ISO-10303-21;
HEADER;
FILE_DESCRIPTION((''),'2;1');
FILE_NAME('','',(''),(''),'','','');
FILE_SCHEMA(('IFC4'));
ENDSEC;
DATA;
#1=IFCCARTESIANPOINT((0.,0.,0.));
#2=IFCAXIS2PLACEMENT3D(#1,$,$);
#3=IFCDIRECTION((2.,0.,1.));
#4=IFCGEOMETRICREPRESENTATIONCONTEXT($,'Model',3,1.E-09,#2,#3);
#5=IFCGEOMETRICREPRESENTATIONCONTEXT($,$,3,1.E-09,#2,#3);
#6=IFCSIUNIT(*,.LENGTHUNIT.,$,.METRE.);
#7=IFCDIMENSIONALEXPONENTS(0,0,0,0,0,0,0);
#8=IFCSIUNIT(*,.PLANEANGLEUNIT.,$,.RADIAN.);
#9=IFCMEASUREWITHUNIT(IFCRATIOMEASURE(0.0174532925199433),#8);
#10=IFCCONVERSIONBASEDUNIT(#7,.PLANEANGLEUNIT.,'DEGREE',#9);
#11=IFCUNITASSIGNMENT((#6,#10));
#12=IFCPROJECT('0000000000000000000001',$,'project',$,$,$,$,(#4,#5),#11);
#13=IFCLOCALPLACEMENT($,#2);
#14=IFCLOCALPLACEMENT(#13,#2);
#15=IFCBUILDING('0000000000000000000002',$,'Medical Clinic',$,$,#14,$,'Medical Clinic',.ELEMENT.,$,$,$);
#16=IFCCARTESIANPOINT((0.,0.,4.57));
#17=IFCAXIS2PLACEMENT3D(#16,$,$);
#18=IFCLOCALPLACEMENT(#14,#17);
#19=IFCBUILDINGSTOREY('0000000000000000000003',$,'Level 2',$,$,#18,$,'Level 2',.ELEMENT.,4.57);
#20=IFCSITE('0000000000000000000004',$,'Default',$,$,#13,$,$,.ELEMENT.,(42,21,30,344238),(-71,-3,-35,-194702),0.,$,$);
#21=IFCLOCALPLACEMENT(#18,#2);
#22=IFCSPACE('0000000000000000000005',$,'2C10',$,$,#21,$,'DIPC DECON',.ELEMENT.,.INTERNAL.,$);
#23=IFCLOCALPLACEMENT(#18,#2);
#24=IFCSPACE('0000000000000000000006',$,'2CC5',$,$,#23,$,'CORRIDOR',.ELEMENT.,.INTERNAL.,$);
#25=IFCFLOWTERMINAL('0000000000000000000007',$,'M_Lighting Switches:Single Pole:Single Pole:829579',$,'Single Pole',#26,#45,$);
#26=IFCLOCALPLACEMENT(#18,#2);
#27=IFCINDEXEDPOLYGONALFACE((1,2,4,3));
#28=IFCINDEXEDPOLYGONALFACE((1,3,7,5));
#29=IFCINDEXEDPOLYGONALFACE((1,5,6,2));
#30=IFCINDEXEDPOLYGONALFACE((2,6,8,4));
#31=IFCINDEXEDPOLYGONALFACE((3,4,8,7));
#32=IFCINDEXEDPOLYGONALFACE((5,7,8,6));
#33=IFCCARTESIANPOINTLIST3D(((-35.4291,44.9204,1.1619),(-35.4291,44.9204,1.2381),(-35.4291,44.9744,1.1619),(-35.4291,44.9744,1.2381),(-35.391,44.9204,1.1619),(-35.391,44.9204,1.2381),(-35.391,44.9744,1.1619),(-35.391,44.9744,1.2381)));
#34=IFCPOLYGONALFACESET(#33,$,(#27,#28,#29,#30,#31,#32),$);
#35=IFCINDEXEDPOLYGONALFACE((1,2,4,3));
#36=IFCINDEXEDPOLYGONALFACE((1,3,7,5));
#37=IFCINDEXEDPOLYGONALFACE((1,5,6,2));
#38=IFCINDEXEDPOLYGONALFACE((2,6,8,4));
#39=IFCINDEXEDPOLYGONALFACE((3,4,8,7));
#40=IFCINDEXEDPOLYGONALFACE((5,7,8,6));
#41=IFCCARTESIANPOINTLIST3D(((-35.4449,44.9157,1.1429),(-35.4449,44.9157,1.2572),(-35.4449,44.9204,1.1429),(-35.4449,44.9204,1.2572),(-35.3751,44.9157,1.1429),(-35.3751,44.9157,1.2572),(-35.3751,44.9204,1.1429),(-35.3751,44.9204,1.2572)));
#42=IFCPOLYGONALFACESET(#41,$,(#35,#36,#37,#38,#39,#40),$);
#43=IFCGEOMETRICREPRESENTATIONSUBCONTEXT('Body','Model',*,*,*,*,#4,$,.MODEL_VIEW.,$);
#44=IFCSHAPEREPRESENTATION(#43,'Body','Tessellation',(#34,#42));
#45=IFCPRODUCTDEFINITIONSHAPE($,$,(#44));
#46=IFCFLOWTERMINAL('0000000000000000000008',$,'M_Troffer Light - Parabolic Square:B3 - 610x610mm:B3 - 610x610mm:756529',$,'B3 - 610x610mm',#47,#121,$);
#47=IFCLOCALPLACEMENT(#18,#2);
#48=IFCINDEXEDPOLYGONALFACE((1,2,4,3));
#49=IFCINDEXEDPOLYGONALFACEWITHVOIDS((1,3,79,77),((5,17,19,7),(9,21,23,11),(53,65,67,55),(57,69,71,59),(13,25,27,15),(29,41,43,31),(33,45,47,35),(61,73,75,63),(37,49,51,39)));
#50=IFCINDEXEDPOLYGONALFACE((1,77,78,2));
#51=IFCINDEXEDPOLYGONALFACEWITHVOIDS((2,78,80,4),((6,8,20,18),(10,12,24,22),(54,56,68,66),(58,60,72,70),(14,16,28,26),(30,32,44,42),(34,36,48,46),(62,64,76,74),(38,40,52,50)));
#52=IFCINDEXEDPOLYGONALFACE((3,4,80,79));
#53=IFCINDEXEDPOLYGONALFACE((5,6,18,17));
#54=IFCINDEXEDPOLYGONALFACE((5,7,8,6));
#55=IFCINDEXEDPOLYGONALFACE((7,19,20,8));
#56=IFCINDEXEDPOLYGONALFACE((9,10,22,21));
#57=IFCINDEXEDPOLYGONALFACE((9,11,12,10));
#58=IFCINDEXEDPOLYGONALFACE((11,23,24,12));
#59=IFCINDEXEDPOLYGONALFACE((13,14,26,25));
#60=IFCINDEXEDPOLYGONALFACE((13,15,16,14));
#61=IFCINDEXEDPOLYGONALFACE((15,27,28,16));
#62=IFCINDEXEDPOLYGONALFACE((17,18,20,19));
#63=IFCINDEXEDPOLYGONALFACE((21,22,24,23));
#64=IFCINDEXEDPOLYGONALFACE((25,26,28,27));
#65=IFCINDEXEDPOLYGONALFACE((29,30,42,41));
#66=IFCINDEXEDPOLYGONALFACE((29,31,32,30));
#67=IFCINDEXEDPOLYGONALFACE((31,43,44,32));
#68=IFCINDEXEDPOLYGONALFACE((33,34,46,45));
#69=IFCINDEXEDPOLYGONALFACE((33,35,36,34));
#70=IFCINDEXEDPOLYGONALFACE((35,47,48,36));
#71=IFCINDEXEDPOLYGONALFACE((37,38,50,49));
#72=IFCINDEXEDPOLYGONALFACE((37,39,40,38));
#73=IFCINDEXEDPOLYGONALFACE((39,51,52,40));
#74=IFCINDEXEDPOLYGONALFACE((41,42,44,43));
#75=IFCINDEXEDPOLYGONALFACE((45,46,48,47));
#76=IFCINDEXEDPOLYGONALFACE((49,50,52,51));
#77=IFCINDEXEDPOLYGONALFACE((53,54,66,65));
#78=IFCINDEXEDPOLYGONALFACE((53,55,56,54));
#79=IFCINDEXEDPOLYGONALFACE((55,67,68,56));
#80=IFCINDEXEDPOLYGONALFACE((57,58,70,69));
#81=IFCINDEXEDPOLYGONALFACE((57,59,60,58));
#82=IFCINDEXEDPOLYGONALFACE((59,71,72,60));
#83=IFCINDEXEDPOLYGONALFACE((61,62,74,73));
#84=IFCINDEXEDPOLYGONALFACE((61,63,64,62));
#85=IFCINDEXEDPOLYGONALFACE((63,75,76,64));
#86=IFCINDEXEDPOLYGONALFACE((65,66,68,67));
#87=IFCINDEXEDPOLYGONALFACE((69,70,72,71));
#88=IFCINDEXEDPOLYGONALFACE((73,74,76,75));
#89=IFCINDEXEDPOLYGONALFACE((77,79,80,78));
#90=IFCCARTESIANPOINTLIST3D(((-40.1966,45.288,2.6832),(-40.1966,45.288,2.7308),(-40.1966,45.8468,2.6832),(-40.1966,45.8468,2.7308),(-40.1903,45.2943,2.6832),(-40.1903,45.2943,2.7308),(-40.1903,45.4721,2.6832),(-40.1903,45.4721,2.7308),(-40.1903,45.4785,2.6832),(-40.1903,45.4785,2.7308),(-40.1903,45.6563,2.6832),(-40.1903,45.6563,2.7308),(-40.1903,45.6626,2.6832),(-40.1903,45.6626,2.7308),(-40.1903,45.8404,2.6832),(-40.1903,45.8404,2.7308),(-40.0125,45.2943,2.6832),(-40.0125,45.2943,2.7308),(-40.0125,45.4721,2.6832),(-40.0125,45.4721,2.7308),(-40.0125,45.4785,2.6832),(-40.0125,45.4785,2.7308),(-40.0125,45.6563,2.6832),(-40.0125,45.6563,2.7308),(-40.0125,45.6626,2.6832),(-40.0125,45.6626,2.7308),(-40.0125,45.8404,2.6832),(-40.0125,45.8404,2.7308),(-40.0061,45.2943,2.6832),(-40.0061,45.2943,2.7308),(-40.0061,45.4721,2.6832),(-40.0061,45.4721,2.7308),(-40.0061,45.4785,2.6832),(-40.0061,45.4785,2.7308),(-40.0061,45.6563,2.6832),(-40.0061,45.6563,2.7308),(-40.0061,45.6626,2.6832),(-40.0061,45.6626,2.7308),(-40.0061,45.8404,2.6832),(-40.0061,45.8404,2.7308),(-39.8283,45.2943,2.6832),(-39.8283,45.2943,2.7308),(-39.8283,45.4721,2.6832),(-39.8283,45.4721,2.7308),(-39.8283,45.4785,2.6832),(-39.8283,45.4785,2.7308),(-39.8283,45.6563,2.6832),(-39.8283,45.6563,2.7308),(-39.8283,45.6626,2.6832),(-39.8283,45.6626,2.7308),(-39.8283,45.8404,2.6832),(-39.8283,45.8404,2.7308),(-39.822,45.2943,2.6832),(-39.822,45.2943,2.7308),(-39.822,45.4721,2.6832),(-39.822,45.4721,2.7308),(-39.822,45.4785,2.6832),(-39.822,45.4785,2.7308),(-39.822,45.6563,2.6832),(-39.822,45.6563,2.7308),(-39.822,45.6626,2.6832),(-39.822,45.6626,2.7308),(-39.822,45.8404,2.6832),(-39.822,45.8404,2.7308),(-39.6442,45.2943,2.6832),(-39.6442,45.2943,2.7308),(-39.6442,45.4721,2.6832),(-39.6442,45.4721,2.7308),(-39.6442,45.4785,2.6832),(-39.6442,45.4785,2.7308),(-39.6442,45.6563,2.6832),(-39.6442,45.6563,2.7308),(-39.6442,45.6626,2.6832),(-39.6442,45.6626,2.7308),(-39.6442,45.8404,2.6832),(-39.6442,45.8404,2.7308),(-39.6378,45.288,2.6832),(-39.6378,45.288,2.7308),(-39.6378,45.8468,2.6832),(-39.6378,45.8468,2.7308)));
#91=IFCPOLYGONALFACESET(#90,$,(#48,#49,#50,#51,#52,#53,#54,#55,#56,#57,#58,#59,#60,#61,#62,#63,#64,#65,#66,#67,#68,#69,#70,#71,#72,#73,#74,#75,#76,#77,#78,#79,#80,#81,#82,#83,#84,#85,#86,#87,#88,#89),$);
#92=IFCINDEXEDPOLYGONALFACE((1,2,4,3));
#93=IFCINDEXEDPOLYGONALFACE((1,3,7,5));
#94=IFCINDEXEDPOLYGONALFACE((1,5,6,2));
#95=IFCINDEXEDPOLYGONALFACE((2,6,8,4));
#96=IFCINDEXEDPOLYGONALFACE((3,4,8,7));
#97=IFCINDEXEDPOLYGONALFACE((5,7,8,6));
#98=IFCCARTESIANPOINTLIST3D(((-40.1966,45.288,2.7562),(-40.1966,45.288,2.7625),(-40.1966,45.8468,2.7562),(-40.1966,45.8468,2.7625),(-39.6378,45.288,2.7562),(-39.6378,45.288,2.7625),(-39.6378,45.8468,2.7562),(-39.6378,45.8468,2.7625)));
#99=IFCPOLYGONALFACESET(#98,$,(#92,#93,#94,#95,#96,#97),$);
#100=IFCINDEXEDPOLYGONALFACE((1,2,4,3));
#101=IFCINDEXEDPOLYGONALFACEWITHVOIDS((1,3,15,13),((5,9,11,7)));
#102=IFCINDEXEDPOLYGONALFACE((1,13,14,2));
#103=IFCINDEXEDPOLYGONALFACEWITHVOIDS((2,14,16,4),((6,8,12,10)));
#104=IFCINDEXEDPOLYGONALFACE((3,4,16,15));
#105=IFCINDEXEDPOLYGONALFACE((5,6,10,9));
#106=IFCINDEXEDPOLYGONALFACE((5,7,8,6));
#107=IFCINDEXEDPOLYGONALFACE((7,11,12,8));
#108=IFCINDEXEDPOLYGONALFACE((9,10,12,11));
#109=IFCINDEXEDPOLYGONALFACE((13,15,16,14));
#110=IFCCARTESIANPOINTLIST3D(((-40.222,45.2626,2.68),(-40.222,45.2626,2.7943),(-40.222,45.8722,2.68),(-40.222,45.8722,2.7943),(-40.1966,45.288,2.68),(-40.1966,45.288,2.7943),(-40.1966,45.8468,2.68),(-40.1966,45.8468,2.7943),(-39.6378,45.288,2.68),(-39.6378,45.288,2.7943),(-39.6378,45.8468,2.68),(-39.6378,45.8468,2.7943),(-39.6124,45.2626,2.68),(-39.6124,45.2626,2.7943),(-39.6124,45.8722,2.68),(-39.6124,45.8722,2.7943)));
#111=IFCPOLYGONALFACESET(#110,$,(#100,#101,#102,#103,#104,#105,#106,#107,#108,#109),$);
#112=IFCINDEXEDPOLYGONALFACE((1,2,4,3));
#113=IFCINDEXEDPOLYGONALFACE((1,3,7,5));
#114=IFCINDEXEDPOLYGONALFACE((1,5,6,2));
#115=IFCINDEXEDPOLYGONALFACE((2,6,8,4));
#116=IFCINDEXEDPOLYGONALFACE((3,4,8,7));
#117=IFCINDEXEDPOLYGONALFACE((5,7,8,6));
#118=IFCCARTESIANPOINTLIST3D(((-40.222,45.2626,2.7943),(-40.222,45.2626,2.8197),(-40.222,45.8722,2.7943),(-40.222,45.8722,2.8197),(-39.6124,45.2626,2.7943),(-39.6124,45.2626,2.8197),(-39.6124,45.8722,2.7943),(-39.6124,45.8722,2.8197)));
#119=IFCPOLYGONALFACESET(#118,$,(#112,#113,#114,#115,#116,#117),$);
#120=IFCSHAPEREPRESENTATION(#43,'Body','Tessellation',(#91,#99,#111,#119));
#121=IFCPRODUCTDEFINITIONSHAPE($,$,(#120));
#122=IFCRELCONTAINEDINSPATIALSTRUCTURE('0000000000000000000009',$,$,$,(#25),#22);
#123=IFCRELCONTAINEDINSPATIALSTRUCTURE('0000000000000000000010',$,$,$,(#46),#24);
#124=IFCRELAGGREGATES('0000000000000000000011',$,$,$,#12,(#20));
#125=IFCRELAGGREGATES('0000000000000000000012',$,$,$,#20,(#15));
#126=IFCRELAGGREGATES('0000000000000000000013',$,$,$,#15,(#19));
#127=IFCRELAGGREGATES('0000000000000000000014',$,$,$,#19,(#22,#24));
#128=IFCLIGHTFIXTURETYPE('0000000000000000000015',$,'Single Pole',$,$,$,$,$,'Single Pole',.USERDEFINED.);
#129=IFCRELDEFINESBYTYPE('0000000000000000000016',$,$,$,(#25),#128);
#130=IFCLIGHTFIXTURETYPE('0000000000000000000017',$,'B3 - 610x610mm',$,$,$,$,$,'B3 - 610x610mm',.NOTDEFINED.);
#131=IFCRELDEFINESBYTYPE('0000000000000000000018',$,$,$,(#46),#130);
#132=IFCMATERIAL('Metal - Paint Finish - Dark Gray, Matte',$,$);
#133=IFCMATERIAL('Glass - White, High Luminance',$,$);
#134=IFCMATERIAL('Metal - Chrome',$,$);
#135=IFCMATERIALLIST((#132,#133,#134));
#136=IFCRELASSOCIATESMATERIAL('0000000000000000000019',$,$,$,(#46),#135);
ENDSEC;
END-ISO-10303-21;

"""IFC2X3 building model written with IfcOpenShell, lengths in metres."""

from ifc_helpers import new_model, entity, si_unit, converted_unit, direction, frame, frame_2d, origin, origin_2d_with_axis, place, context, subcontext, project, spatial, polyline, rectangle, outline, extrude, source, transform, mapped, material, material_list, type_object, type_shapes, element, save


model = new_model("IFC2X3")

# Units and contexts
model_context = context("Model", 3, precision=1e-09, world=origin(), true_north=direction((2.0, 0.0, 1.0)))
context_of_model = context(None, 3, precision=1e-09, world=origin(), true_north=direction((2.0, 0.0, 1.0)))
body_context = subcontext(model_context, "Body", "Model", "MODEL_VIEW")
ifc_project = project(units=[si_unit("LENGTHUNIT", "METRE"), converted_unit("PLANEANGLEUNIT", "DEGREE", entity("IfcRatioMeasure", 0.0174532925199433), si_unit("PLANEANGLEUNIT", "RADIAN"), dimensions=[0, 0, 0, 0, 0, 0, 0])], contexts=[model_context, context_of_model])

# Site, building, storey
site_placement = place(None, origin())
site = spatial("IfcSite", under=ifc_project, at=site_placement, Name="Default", CompositionType="ELEMENT", RefLatitude=(42, 21, 30, 344238), RefLongitude=(-71, -3, -35, -194702), RefElevation=0.0)
building_placement = place(site_placement, origin())
building = spatial("IfcBuilding", under=site, at=building_placement, Name="Medical Clinic", LongName="Medical Clinic", CompositionType="ELEMENT")
storey_placement = place(building_placement, frame((0.0, 0.0, 4.57)))
storey = spatial("IfcBuildingStorey", under=building, at=storey_placement, Name="Level 2", LongName="Level 2", CompositionType="ELEMENT", Elevation=4.57)

# Shared definitions
space_1_placement = place(storey_placement, origin())
space_1 = spatial("IfcSpace", under=storey, at=space_1_placement, Name="2C10", LongName="DIPC DECON", CompositionType="ELEMENT", InteriorOrExteriorSpace="INTERNAL")

# Shared definitions
light_fixture_type_1 = type_object("IfcLightFixtureType", Name="Single Pole", ElementType="Single Pole", PredefinedType="USERDEFINED")
shared_shape_1 = source(origin(), body_context, "Body", "SweptSolid", [
    extrude(rectangle(XDim=0.0381, YDim=0.0762, at=origin_2d_with_axis()), frame((0.0, 0.0, -0.054), z_axis=(0.0, 0.0, 1.0), x_axis=(-1.0, 0.0, 0.0)), (0.0, 0.0, 1.0), 0.054),
    extrude(rectangle(XDim=0.0698, YDim=0.1143, at=frame_2d((0.0, 0.0), x_axis=(1.0, 0.0))), frame((0.0, 0.0, 0.0), z_axis=(0.0, 0.0, 1.0), x_axis=(-1.0, 0.0, 0.0)), (0.0, 0.0, 1.0), 0.0048),
])
type_shapes(light_fixture_type_1, [shared_shape_1])

# Shared definitions
space_2_placement = place(storey_placement, origin())
space_2 = spatial("IfcSpace", under=storey, at=space_2_placement, Name="2CC5", LongName="CORRIDOR", CompositionType="ELEMENT", InteriorOrExteriorSpace="INTERNAL")

# Flow terminals
flow_terminal_1_placement = place(space_1_placement, frame((-35.41, 44.9204, 1.2), z_axis=(0.0, -1.0, 0.0), x_axis=(1.0, 0.0, 0.0)))
element("IfcFlowTerminal", 1, at=flow_terminal_1_placement, inside=space_1, type_object=light_fixture_type_1, Name="M_Lighting Switches:Single Pole:Single Pole:829579", ObjectType="Single Pole", context=body_context, shape_type="MappedRepresentation", body=[
    mapped(shared_shape_1, transform((0.0, 0.0, 0.0), scale=1.0)),
])
ifc_material_1 = material(Name="Metal - Paint Finish - Dark Gray, Matte")
ifc_material_2 = material(Name="Glass - White, High Luminance")
ifc_material_3 = material(Name="Metal - Chrome")
ifc_material_list_1 = material_list([ifc_material_1, ifc_material_2, ifc_material_3])
light_fixture_type_2 = type_object("IfcLightFixtureType", Name="B3 - 610x610mm", ElementType="B3 - 610x610mm", PredefinedType="NOTDEFINED")
shared_shape_2 = source(origin(), body_context, "Body", "SweptSolid", [
    extrude(outline(polyline([(-0.2794, -0.2794), (0.2794, -0.2794), (0.2794, 0.2794), (-0.2794, 0.2794), (-0.2794, -0.2794)]), holes=[polyline([(-0.0952, 0.0953), (-0.273, 0.0953), (-0.273, 0.2731), (-0.0952, 0.2731), (-0.0952, 0.0953)]), polyline([(0.2731, 0.0953), (0.0953, 0.0953), (0.0953, 0.2731), (0.2731, 0.2731), (0.2731, 0.0953)]), polyline([(-0.0889, 0.2731), (0.0889, 0.2731), (0.0889, 0.0953), (-0.0889, 0.0953), (-0.0889, 0.2731)]), polyline([(0.2731, -0.273), (0.0953, -0.273), (0.0953, -0.0952), (0.2731, -0.0952), (0.2731, -0.273)]), polyline([(0.0889, -0.273), (-0.0889, -0.273), (-0.0889, -0.0952), (0.0889, -0.0952), (0.0889, -0.273)]), polyline([(-0.0952, -0.273), (-0.273, -0.273), (-0.273, -0.0952), (-0.0952, -0.0952), (-0.0952, -0.273)]), polyline([(-0.0952, -0.0889), (-0.273, -0.0889), (-0.273, 0.0889), (-0.0952, 0.0889), (-0.0952, -0.0889)]), polyline([(0.0889, -0.0889), (-0.0889, -0.0889), (-0.0889, 0.0889), (0.0889, 0.0889), (0.0889, -0.0889)]), polyline([(0.2731, -0.0889), (0.0953, -0.0889), (0.0953, 0.0889), (0.2731, 0.0889), (0.2731, -0.0889)])]), frame((0.0, -0.3048, -0.0508), z_axis=(0.0, 0.0, 1.0), x_axis=(-1.0, 0.0, 0.0)), (0.0, 0.0, 1.0), 0.0476),
    extrude(rectangle(XDim=0.5588, YDim=0.5588, at=origin_2d_with_axis()), frame((0.0, -0.3048, -0.0825), z_axis=(0.0, 0.0, 1.0), x_axis=(-1.0, 0.0, 0.0)), (0.0, 0.0, 1.0), 0.0064),
    extrude(outline(polyline([(-0.3048, -0.3048), (0.3048, -0.3048), (0.3048, 0.3048), (-0.3048, 0.3048), (-0.3048, -0.3048)]), holes=[polyline([(0.2794, 0.2794), (0.2794, -0.2794), (-0.2794, -0.2794), (-0.2794, 0.2794), (0.2794, 0.2794)])]), frame((0.0, -0.3048, -0.1143)), (0.0, 0.0, 1.0), 0.1143),
    extrude(rectangle(XDim=0.6096, YDim=0.6096, at=origin_2d_with_axis()), frame((0.0, -0.3048, -0.1397), z_axis=(0.0, 0.0, 1.0), x_axis=(-1.0, 0.0, 0.0)), (0.0, 0.0, 1.0), 0.0254),
])
type_shapes(light_fixture_type_2, [shared_shape_2])
flow_terminal_2_placement = place(space_2_placement, frame((-39.9172, 45.2626, 2.68), z_axis=(0.0, 0.0, -1.0), x_axis=(1.0, 0.0, 0.0)))
element("IfcFlowTerminal", 2, at=flow_terminal_2_placement, inside=space_2, type_object=light_fixture_type_2, material=ifc_material_list_1, Name="M_Troffer Light - Parabolic Square:B3 - 610x610mm:B3 - 610x610mm:756529", ObjectType="B3 - 610x610mm", context=body_context, shape_type="MappedRepresentation", body=[
    mapped(shared_shape_2, transform((0.0, 0.0, 0.0), scale=1.0)),
])

save(model, "model.ifc")
